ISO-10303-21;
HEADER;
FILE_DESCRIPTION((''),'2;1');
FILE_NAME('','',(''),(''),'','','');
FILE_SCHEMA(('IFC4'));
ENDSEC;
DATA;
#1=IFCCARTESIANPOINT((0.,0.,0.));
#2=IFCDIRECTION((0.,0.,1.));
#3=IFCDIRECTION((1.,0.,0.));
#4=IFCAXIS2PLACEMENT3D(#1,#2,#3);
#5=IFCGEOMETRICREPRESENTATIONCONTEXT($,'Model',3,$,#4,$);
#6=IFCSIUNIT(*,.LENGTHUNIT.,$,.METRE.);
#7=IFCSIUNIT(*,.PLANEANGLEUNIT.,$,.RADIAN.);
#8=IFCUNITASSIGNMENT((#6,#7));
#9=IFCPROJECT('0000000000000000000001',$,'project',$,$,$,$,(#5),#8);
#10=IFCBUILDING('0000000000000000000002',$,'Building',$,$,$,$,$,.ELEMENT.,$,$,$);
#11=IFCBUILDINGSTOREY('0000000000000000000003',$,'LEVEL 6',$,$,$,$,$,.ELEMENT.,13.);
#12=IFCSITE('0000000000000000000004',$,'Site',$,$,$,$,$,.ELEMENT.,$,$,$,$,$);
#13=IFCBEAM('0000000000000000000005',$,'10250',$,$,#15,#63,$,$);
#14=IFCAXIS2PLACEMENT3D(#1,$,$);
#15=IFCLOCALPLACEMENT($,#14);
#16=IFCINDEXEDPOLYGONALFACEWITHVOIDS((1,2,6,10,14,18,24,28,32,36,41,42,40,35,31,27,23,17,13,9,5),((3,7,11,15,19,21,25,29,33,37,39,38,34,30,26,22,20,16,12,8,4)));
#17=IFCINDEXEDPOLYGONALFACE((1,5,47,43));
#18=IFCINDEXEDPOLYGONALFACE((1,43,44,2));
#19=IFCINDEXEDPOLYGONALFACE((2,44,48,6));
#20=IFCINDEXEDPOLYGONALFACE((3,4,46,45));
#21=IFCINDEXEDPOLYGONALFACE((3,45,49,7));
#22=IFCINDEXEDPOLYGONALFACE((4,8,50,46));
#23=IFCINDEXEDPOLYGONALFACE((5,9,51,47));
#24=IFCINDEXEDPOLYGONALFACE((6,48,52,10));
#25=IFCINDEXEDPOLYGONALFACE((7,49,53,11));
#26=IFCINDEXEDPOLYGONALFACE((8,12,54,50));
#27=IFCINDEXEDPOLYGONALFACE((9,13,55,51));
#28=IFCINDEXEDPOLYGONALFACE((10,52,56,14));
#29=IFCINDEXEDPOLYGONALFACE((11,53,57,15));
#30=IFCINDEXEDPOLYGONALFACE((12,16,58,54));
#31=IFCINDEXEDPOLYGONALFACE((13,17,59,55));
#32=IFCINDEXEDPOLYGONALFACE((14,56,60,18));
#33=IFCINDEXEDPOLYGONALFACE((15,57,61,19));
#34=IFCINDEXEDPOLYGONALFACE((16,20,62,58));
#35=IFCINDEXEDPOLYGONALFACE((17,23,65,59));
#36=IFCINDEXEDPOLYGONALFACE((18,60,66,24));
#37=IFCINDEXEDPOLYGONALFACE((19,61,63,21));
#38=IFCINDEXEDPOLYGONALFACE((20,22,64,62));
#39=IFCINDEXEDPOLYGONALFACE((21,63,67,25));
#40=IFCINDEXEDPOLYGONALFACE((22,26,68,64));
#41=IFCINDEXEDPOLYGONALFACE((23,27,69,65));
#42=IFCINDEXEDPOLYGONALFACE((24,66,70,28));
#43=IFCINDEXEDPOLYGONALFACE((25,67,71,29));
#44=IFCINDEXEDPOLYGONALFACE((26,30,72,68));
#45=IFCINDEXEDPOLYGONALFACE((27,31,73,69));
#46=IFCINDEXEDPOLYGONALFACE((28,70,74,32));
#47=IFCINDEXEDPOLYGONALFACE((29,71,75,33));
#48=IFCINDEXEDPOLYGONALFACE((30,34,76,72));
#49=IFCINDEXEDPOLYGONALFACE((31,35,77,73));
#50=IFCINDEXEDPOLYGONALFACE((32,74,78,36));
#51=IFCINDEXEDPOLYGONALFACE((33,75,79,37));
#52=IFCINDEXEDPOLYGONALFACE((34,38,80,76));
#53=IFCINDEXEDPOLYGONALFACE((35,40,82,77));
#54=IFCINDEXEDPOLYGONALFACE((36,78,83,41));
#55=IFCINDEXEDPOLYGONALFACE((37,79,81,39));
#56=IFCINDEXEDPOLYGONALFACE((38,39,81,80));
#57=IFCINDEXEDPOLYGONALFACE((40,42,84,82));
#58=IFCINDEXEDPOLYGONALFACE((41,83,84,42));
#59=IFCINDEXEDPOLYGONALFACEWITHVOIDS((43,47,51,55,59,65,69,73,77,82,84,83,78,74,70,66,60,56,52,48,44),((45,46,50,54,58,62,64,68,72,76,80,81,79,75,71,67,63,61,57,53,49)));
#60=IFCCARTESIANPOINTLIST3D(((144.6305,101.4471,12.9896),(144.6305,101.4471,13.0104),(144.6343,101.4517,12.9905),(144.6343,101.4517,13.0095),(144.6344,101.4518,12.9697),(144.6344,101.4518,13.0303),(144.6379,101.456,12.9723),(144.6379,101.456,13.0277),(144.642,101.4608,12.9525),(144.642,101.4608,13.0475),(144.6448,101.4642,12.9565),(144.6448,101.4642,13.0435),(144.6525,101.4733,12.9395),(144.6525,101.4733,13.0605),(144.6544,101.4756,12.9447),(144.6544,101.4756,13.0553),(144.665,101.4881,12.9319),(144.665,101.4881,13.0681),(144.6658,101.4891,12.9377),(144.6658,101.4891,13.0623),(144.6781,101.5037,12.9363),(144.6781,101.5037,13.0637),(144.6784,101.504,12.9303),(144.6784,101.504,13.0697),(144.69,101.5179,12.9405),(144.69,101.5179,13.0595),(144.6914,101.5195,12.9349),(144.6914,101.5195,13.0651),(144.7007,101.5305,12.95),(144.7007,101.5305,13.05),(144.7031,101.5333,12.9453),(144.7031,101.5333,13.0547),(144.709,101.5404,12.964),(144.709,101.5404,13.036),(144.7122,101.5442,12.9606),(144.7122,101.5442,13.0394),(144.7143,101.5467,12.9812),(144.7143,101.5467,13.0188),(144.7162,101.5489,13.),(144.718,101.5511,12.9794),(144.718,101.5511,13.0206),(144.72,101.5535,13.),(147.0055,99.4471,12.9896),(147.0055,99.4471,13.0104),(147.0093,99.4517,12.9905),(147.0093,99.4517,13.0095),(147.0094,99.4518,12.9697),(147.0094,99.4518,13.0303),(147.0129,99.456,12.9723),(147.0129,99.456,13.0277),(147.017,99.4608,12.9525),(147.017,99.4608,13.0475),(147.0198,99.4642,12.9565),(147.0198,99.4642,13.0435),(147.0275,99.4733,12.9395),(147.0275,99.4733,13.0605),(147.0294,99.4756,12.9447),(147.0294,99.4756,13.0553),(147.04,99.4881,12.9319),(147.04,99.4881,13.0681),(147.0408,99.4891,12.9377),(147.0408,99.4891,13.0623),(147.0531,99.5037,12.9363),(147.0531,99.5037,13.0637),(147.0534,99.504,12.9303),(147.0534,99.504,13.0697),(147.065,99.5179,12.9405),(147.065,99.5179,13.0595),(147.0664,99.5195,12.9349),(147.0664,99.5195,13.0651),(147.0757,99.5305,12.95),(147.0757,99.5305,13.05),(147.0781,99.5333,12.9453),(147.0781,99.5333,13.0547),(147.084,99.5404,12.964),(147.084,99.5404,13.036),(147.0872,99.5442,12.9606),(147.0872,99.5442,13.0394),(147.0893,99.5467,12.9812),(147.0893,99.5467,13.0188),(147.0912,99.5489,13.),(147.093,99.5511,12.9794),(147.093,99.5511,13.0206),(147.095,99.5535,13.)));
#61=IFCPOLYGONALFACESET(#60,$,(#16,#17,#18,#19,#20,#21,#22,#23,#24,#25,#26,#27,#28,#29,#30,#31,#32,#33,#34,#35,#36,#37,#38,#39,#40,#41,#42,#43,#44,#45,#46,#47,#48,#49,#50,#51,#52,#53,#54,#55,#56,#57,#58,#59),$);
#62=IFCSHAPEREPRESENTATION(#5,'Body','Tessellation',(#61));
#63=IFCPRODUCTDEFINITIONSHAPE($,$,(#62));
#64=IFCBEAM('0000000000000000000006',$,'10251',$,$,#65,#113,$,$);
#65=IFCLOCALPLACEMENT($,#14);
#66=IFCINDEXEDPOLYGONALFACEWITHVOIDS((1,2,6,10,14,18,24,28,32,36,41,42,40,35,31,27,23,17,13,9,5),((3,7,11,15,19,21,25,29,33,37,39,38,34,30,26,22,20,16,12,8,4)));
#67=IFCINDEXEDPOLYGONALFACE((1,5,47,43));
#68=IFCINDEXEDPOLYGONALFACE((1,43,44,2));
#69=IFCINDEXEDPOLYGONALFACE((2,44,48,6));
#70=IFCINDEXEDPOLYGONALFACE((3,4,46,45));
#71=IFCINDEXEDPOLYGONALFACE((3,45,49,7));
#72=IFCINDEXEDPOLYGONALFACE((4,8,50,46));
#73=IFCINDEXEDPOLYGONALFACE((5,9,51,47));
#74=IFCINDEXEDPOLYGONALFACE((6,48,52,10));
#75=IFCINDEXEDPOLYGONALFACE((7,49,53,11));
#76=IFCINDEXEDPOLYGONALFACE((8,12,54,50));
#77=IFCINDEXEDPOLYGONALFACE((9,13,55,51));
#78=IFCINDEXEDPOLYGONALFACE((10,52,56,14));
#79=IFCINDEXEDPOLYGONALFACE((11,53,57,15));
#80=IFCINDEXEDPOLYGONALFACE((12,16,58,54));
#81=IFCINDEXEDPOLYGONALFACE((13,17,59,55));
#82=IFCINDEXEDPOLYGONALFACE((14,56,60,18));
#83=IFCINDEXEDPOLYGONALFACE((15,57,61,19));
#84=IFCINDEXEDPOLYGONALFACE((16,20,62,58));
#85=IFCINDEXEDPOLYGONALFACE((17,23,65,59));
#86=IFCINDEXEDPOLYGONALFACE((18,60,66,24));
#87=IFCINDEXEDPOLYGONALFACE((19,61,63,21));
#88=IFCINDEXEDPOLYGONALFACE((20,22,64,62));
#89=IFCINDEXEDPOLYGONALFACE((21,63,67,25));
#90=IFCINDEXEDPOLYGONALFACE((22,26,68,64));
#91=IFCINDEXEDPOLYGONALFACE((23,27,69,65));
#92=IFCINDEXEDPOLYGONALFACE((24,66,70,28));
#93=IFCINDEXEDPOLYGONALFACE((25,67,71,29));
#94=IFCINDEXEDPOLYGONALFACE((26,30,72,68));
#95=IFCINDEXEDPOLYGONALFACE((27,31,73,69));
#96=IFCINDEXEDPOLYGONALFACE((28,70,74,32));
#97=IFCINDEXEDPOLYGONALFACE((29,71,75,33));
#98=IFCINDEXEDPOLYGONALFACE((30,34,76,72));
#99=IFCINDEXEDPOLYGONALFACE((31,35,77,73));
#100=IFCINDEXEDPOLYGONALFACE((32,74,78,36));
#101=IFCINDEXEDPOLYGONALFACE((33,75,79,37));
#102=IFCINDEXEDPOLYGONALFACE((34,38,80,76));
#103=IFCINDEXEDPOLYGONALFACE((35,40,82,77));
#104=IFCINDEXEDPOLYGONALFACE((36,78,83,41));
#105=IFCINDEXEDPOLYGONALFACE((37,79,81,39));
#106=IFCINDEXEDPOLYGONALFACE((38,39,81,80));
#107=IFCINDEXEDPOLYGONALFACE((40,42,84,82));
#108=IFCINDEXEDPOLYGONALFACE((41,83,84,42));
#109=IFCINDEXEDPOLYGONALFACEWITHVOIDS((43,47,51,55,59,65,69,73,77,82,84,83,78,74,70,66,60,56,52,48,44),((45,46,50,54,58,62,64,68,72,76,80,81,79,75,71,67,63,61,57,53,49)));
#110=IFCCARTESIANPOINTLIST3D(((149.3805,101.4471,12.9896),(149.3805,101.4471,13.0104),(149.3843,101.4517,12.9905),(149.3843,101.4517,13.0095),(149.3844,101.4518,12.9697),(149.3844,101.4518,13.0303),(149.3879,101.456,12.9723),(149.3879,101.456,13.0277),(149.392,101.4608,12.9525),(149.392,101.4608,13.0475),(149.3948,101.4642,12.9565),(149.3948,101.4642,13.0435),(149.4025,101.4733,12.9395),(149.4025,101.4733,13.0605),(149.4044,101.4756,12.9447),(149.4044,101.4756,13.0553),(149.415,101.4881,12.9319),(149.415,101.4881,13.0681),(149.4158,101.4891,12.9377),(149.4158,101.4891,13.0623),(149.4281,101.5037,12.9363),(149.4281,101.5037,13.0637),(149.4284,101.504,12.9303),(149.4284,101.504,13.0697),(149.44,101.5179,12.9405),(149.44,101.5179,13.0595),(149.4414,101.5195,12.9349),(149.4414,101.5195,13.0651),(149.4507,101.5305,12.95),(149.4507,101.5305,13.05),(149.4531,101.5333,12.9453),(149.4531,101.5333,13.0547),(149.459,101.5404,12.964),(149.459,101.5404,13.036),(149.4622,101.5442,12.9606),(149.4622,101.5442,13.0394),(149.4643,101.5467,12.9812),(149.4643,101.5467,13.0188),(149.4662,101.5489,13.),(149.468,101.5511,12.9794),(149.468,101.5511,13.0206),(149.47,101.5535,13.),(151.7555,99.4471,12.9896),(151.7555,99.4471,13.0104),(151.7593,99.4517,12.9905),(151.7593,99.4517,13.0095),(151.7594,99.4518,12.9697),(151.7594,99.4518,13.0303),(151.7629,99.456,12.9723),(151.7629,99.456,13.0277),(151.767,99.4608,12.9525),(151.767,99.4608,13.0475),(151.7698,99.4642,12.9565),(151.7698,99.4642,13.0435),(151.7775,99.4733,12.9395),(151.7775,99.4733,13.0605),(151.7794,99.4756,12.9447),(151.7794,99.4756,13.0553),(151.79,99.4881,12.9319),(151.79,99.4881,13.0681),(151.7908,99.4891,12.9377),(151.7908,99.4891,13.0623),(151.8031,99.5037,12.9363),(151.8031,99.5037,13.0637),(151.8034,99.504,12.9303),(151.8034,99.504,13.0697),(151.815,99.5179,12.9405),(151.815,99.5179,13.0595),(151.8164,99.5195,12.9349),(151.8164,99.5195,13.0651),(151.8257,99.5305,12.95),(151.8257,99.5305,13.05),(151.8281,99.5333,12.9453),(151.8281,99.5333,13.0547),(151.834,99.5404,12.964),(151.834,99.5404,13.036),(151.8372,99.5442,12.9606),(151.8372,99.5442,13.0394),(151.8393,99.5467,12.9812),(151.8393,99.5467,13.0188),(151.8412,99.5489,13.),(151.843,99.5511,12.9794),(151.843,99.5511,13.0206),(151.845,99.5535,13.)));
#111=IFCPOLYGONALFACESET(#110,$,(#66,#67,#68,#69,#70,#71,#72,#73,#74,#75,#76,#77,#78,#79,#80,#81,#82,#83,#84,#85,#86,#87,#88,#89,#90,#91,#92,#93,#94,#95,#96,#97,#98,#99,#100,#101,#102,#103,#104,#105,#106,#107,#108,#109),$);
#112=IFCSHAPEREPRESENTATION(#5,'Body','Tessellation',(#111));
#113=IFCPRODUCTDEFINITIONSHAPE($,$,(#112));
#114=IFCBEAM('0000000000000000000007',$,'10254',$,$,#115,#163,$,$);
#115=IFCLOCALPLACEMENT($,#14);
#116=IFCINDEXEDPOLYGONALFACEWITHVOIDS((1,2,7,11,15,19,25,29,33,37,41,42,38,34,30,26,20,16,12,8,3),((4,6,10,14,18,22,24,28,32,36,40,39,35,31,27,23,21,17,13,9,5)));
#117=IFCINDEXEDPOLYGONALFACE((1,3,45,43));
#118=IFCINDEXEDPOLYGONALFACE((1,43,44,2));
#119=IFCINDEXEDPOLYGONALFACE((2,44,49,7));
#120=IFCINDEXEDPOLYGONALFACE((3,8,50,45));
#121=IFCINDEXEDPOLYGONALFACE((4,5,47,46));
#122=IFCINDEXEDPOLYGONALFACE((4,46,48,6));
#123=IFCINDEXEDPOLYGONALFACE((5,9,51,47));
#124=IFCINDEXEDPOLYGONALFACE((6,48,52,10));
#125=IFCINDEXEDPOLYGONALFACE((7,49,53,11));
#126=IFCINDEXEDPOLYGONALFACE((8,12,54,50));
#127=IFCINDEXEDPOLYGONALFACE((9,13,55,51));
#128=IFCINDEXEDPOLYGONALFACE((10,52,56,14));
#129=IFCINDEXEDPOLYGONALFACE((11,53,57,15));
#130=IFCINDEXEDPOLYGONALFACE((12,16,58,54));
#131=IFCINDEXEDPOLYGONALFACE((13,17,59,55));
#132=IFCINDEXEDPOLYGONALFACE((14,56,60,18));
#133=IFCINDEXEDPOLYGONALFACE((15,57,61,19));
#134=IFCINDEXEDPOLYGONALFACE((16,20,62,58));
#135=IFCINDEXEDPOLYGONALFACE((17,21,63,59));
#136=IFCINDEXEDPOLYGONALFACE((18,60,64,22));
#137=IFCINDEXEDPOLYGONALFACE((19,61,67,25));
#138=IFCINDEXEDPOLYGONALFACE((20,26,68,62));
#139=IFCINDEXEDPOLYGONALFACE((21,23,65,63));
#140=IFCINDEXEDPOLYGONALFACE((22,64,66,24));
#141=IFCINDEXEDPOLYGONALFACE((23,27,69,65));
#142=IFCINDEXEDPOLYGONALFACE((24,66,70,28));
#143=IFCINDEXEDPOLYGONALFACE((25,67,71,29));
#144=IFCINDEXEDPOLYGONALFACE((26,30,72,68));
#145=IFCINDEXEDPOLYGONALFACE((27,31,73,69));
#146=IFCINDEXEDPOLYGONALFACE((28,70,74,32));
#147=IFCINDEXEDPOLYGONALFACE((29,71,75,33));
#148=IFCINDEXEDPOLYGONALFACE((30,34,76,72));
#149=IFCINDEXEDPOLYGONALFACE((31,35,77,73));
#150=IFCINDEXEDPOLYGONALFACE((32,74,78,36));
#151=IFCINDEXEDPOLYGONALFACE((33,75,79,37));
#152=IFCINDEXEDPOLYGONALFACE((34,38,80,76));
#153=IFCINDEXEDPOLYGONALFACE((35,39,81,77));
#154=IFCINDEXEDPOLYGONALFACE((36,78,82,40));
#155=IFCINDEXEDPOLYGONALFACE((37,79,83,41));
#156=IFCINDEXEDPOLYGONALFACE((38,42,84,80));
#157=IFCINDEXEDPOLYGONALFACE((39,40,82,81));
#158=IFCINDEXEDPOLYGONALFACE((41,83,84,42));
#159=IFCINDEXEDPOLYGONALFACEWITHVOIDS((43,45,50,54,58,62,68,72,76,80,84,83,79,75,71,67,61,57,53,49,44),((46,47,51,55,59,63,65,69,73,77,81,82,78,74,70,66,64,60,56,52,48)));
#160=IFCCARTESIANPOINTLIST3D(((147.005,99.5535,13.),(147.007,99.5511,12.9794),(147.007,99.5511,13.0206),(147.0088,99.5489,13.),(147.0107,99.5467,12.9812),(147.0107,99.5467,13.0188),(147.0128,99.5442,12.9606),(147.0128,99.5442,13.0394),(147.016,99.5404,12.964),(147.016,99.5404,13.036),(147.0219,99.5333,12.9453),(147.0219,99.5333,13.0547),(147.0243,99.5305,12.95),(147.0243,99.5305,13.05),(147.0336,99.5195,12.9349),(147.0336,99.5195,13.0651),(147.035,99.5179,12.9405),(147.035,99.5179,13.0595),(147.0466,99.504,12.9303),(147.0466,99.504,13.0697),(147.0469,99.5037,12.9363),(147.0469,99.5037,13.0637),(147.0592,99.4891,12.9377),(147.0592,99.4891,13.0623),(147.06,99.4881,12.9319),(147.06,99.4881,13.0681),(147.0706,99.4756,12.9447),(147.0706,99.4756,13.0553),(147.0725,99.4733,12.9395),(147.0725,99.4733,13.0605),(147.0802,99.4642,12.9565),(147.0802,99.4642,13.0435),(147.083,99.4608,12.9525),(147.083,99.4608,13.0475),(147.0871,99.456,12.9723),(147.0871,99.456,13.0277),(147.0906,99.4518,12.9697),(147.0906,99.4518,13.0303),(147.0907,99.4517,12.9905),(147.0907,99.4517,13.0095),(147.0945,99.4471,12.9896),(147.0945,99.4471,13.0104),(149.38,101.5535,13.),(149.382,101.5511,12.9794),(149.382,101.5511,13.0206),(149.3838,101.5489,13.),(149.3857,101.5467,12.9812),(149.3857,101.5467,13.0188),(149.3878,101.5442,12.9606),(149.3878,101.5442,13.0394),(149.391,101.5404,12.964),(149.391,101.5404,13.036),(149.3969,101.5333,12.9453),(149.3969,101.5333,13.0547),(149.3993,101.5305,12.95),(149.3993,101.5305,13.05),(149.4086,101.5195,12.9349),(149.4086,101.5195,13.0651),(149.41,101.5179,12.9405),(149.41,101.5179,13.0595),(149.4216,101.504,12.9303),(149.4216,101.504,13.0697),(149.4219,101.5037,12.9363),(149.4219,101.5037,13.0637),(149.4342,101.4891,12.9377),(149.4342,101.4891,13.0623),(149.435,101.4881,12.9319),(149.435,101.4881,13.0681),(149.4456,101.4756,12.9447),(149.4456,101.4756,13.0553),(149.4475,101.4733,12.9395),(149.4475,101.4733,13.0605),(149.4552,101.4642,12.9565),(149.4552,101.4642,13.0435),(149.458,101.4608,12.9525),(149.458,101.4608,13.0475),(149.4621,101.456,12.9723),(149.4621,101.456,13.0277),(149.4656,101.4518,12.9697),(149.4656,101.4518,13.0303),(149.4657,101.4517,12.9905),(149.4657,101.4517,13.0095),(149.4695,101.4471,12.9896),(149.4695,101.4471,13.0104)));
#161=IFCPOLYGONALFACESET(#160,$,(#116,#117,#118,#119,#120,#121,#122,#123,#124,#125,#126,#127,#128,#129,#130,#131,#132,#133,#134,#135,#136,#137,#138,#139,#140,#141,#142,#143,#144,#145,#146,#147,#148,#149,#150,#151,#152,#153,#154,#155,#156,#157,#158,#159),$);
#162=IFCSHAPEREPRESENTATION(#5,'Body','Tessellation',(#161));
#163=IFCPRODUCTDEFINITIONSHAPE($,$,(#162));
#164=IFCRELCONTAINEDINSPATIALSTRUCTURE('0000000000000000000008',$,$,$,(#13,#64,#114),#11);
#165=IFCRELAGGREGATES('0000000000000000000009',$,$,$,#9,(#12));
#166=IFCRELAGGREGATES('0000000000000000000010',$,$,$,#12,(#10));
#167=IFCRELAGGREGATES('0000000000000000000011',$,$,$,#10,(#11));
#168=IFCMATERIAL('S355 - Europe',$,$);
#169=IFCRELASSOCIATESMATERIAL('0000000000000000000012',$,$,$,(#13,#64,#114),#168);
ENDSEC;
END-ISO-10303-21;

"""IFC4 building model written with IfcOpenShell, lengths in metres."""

from ifc_helpers import new_model, si_unit, frame, origin_with_axes, origin_2d_with_axis, place, context, project, spatial, hollow_circle, extrude, material, material_profile, profile_set, profile_usage, element, save


model = new_model("IFC4")

# Units and contexts
model_context = context("Model", 3, world=origin_with_axes())
ifc_project = project(units=[si_unit("LENGTHUNIT", "METRE"), si_unit("PLANEANGLEUNIT", "RADIAN")], contexts=[model_context])

# Site, building, storey
site = spatial("IfcSite", under=ifc_project, Name="Site", CompositionType="ELEMENT")
building = spatial("IfcBuilding", under=site, Name="Building", CompositionType="ELEMENT")
storey = spatial("IfcBuildingStorey", under=building, Name="LEVEL 6", CompositionType="ELEMENT", Elevation=13.0)

# Shared definitions
ifc_material = material(Name="S355 - Europe")

# Beams
ifc_material_profile_1 = material_profile(ifc_material, hollow_circle(Radius=0.0699, WallThickness=0.006, at=origin_2d_with_axis()))
ifc_profile_set_1 = profile_set([ifc_material_profile_1])
ifc_profile_usage_1 = profile_usage(ifc_profile_set_1, cardinal=10)
beam_1_placement = place(None, frame((144.675, 101.5, 13.0), z_axis=(0.764911, -0.644136, 0.0), x_axis=(0.644136, 0.764911, 0.0)))
element("IfcBeam", 1, at=beam_1_placement, inside=storey, material=ifc_profile_usage_1, Name="10250", context=model_context, shape_type="SweptSolid", body=[
    extrude(hollow_circle(Radius=0.0699, WallThickness=0.006, at=origin_2d_with_axis()), origin_with_axes(), (0.0, 0.0, 1.0), 3.1049),
])
ifc_material_profile_2 = material_profile(ifc_material, hollow_circle(Radius=0.0699, WallThickness=0.006, at=origin_2d_with_axis()))
ifc_profile_set_2 = profile_set([ifc_material_profile_2])
ifc_profile_usage_2 = profile_usage(ifc_profile_set_2, cardinal=10)
beam_2_placement = place(None, frame((149.425, 101.5, 13.0), z_axis=(0.764911, -0.644136, 0.0), x_axis=(0.644136, 0.764911, 0.0)))
element("IfcBeam", 2, at=beam_2_placement, inside=storey, material=ifc_profile_usage_2, Name="10251", context=model_context, shape_type="SweptSolid", body=[
    extrude(hollow_circle(Radius=0.0699, WallThickness=0.006, at=origin_2d_with_axis()), origin_with_axes(), (0.0, 0.0, 1.0), 3.1049),
])
ifc_material_profile_3 = material_profile(ifc_material, hollow_circle(Radius=0.0699, WallThickness=0.006, at=origin_2d_with_axis()))
ifc_profile_set_3 = profile_set([ifc_material_profile_3])
ifc_profile_usage_3 = profile_usage(ifc_profile_set_3, cardinal=10)
beam_3_placement = place(None, frame((147.05, 99.5, 13.0), z_axis=(0.764911, 0.644136, 0.0), x_axis=(-0.644136, 0.764911, 0.0)))
element("IfcBeam", 3, at=beam_3_placement, inside=storey, material=ifc_profile_usage_3, Name="10254", context=model_context, shape_type="SweptSolid", body=[
    extrude(hollow_circle(Radius=0.0699, WallThickness=0.006, at=origin_2d_with_axis()), origin_with_axes(), (0.0, 0.0, 1.0), 3.1049),
])

save(model, "model.ifc")
